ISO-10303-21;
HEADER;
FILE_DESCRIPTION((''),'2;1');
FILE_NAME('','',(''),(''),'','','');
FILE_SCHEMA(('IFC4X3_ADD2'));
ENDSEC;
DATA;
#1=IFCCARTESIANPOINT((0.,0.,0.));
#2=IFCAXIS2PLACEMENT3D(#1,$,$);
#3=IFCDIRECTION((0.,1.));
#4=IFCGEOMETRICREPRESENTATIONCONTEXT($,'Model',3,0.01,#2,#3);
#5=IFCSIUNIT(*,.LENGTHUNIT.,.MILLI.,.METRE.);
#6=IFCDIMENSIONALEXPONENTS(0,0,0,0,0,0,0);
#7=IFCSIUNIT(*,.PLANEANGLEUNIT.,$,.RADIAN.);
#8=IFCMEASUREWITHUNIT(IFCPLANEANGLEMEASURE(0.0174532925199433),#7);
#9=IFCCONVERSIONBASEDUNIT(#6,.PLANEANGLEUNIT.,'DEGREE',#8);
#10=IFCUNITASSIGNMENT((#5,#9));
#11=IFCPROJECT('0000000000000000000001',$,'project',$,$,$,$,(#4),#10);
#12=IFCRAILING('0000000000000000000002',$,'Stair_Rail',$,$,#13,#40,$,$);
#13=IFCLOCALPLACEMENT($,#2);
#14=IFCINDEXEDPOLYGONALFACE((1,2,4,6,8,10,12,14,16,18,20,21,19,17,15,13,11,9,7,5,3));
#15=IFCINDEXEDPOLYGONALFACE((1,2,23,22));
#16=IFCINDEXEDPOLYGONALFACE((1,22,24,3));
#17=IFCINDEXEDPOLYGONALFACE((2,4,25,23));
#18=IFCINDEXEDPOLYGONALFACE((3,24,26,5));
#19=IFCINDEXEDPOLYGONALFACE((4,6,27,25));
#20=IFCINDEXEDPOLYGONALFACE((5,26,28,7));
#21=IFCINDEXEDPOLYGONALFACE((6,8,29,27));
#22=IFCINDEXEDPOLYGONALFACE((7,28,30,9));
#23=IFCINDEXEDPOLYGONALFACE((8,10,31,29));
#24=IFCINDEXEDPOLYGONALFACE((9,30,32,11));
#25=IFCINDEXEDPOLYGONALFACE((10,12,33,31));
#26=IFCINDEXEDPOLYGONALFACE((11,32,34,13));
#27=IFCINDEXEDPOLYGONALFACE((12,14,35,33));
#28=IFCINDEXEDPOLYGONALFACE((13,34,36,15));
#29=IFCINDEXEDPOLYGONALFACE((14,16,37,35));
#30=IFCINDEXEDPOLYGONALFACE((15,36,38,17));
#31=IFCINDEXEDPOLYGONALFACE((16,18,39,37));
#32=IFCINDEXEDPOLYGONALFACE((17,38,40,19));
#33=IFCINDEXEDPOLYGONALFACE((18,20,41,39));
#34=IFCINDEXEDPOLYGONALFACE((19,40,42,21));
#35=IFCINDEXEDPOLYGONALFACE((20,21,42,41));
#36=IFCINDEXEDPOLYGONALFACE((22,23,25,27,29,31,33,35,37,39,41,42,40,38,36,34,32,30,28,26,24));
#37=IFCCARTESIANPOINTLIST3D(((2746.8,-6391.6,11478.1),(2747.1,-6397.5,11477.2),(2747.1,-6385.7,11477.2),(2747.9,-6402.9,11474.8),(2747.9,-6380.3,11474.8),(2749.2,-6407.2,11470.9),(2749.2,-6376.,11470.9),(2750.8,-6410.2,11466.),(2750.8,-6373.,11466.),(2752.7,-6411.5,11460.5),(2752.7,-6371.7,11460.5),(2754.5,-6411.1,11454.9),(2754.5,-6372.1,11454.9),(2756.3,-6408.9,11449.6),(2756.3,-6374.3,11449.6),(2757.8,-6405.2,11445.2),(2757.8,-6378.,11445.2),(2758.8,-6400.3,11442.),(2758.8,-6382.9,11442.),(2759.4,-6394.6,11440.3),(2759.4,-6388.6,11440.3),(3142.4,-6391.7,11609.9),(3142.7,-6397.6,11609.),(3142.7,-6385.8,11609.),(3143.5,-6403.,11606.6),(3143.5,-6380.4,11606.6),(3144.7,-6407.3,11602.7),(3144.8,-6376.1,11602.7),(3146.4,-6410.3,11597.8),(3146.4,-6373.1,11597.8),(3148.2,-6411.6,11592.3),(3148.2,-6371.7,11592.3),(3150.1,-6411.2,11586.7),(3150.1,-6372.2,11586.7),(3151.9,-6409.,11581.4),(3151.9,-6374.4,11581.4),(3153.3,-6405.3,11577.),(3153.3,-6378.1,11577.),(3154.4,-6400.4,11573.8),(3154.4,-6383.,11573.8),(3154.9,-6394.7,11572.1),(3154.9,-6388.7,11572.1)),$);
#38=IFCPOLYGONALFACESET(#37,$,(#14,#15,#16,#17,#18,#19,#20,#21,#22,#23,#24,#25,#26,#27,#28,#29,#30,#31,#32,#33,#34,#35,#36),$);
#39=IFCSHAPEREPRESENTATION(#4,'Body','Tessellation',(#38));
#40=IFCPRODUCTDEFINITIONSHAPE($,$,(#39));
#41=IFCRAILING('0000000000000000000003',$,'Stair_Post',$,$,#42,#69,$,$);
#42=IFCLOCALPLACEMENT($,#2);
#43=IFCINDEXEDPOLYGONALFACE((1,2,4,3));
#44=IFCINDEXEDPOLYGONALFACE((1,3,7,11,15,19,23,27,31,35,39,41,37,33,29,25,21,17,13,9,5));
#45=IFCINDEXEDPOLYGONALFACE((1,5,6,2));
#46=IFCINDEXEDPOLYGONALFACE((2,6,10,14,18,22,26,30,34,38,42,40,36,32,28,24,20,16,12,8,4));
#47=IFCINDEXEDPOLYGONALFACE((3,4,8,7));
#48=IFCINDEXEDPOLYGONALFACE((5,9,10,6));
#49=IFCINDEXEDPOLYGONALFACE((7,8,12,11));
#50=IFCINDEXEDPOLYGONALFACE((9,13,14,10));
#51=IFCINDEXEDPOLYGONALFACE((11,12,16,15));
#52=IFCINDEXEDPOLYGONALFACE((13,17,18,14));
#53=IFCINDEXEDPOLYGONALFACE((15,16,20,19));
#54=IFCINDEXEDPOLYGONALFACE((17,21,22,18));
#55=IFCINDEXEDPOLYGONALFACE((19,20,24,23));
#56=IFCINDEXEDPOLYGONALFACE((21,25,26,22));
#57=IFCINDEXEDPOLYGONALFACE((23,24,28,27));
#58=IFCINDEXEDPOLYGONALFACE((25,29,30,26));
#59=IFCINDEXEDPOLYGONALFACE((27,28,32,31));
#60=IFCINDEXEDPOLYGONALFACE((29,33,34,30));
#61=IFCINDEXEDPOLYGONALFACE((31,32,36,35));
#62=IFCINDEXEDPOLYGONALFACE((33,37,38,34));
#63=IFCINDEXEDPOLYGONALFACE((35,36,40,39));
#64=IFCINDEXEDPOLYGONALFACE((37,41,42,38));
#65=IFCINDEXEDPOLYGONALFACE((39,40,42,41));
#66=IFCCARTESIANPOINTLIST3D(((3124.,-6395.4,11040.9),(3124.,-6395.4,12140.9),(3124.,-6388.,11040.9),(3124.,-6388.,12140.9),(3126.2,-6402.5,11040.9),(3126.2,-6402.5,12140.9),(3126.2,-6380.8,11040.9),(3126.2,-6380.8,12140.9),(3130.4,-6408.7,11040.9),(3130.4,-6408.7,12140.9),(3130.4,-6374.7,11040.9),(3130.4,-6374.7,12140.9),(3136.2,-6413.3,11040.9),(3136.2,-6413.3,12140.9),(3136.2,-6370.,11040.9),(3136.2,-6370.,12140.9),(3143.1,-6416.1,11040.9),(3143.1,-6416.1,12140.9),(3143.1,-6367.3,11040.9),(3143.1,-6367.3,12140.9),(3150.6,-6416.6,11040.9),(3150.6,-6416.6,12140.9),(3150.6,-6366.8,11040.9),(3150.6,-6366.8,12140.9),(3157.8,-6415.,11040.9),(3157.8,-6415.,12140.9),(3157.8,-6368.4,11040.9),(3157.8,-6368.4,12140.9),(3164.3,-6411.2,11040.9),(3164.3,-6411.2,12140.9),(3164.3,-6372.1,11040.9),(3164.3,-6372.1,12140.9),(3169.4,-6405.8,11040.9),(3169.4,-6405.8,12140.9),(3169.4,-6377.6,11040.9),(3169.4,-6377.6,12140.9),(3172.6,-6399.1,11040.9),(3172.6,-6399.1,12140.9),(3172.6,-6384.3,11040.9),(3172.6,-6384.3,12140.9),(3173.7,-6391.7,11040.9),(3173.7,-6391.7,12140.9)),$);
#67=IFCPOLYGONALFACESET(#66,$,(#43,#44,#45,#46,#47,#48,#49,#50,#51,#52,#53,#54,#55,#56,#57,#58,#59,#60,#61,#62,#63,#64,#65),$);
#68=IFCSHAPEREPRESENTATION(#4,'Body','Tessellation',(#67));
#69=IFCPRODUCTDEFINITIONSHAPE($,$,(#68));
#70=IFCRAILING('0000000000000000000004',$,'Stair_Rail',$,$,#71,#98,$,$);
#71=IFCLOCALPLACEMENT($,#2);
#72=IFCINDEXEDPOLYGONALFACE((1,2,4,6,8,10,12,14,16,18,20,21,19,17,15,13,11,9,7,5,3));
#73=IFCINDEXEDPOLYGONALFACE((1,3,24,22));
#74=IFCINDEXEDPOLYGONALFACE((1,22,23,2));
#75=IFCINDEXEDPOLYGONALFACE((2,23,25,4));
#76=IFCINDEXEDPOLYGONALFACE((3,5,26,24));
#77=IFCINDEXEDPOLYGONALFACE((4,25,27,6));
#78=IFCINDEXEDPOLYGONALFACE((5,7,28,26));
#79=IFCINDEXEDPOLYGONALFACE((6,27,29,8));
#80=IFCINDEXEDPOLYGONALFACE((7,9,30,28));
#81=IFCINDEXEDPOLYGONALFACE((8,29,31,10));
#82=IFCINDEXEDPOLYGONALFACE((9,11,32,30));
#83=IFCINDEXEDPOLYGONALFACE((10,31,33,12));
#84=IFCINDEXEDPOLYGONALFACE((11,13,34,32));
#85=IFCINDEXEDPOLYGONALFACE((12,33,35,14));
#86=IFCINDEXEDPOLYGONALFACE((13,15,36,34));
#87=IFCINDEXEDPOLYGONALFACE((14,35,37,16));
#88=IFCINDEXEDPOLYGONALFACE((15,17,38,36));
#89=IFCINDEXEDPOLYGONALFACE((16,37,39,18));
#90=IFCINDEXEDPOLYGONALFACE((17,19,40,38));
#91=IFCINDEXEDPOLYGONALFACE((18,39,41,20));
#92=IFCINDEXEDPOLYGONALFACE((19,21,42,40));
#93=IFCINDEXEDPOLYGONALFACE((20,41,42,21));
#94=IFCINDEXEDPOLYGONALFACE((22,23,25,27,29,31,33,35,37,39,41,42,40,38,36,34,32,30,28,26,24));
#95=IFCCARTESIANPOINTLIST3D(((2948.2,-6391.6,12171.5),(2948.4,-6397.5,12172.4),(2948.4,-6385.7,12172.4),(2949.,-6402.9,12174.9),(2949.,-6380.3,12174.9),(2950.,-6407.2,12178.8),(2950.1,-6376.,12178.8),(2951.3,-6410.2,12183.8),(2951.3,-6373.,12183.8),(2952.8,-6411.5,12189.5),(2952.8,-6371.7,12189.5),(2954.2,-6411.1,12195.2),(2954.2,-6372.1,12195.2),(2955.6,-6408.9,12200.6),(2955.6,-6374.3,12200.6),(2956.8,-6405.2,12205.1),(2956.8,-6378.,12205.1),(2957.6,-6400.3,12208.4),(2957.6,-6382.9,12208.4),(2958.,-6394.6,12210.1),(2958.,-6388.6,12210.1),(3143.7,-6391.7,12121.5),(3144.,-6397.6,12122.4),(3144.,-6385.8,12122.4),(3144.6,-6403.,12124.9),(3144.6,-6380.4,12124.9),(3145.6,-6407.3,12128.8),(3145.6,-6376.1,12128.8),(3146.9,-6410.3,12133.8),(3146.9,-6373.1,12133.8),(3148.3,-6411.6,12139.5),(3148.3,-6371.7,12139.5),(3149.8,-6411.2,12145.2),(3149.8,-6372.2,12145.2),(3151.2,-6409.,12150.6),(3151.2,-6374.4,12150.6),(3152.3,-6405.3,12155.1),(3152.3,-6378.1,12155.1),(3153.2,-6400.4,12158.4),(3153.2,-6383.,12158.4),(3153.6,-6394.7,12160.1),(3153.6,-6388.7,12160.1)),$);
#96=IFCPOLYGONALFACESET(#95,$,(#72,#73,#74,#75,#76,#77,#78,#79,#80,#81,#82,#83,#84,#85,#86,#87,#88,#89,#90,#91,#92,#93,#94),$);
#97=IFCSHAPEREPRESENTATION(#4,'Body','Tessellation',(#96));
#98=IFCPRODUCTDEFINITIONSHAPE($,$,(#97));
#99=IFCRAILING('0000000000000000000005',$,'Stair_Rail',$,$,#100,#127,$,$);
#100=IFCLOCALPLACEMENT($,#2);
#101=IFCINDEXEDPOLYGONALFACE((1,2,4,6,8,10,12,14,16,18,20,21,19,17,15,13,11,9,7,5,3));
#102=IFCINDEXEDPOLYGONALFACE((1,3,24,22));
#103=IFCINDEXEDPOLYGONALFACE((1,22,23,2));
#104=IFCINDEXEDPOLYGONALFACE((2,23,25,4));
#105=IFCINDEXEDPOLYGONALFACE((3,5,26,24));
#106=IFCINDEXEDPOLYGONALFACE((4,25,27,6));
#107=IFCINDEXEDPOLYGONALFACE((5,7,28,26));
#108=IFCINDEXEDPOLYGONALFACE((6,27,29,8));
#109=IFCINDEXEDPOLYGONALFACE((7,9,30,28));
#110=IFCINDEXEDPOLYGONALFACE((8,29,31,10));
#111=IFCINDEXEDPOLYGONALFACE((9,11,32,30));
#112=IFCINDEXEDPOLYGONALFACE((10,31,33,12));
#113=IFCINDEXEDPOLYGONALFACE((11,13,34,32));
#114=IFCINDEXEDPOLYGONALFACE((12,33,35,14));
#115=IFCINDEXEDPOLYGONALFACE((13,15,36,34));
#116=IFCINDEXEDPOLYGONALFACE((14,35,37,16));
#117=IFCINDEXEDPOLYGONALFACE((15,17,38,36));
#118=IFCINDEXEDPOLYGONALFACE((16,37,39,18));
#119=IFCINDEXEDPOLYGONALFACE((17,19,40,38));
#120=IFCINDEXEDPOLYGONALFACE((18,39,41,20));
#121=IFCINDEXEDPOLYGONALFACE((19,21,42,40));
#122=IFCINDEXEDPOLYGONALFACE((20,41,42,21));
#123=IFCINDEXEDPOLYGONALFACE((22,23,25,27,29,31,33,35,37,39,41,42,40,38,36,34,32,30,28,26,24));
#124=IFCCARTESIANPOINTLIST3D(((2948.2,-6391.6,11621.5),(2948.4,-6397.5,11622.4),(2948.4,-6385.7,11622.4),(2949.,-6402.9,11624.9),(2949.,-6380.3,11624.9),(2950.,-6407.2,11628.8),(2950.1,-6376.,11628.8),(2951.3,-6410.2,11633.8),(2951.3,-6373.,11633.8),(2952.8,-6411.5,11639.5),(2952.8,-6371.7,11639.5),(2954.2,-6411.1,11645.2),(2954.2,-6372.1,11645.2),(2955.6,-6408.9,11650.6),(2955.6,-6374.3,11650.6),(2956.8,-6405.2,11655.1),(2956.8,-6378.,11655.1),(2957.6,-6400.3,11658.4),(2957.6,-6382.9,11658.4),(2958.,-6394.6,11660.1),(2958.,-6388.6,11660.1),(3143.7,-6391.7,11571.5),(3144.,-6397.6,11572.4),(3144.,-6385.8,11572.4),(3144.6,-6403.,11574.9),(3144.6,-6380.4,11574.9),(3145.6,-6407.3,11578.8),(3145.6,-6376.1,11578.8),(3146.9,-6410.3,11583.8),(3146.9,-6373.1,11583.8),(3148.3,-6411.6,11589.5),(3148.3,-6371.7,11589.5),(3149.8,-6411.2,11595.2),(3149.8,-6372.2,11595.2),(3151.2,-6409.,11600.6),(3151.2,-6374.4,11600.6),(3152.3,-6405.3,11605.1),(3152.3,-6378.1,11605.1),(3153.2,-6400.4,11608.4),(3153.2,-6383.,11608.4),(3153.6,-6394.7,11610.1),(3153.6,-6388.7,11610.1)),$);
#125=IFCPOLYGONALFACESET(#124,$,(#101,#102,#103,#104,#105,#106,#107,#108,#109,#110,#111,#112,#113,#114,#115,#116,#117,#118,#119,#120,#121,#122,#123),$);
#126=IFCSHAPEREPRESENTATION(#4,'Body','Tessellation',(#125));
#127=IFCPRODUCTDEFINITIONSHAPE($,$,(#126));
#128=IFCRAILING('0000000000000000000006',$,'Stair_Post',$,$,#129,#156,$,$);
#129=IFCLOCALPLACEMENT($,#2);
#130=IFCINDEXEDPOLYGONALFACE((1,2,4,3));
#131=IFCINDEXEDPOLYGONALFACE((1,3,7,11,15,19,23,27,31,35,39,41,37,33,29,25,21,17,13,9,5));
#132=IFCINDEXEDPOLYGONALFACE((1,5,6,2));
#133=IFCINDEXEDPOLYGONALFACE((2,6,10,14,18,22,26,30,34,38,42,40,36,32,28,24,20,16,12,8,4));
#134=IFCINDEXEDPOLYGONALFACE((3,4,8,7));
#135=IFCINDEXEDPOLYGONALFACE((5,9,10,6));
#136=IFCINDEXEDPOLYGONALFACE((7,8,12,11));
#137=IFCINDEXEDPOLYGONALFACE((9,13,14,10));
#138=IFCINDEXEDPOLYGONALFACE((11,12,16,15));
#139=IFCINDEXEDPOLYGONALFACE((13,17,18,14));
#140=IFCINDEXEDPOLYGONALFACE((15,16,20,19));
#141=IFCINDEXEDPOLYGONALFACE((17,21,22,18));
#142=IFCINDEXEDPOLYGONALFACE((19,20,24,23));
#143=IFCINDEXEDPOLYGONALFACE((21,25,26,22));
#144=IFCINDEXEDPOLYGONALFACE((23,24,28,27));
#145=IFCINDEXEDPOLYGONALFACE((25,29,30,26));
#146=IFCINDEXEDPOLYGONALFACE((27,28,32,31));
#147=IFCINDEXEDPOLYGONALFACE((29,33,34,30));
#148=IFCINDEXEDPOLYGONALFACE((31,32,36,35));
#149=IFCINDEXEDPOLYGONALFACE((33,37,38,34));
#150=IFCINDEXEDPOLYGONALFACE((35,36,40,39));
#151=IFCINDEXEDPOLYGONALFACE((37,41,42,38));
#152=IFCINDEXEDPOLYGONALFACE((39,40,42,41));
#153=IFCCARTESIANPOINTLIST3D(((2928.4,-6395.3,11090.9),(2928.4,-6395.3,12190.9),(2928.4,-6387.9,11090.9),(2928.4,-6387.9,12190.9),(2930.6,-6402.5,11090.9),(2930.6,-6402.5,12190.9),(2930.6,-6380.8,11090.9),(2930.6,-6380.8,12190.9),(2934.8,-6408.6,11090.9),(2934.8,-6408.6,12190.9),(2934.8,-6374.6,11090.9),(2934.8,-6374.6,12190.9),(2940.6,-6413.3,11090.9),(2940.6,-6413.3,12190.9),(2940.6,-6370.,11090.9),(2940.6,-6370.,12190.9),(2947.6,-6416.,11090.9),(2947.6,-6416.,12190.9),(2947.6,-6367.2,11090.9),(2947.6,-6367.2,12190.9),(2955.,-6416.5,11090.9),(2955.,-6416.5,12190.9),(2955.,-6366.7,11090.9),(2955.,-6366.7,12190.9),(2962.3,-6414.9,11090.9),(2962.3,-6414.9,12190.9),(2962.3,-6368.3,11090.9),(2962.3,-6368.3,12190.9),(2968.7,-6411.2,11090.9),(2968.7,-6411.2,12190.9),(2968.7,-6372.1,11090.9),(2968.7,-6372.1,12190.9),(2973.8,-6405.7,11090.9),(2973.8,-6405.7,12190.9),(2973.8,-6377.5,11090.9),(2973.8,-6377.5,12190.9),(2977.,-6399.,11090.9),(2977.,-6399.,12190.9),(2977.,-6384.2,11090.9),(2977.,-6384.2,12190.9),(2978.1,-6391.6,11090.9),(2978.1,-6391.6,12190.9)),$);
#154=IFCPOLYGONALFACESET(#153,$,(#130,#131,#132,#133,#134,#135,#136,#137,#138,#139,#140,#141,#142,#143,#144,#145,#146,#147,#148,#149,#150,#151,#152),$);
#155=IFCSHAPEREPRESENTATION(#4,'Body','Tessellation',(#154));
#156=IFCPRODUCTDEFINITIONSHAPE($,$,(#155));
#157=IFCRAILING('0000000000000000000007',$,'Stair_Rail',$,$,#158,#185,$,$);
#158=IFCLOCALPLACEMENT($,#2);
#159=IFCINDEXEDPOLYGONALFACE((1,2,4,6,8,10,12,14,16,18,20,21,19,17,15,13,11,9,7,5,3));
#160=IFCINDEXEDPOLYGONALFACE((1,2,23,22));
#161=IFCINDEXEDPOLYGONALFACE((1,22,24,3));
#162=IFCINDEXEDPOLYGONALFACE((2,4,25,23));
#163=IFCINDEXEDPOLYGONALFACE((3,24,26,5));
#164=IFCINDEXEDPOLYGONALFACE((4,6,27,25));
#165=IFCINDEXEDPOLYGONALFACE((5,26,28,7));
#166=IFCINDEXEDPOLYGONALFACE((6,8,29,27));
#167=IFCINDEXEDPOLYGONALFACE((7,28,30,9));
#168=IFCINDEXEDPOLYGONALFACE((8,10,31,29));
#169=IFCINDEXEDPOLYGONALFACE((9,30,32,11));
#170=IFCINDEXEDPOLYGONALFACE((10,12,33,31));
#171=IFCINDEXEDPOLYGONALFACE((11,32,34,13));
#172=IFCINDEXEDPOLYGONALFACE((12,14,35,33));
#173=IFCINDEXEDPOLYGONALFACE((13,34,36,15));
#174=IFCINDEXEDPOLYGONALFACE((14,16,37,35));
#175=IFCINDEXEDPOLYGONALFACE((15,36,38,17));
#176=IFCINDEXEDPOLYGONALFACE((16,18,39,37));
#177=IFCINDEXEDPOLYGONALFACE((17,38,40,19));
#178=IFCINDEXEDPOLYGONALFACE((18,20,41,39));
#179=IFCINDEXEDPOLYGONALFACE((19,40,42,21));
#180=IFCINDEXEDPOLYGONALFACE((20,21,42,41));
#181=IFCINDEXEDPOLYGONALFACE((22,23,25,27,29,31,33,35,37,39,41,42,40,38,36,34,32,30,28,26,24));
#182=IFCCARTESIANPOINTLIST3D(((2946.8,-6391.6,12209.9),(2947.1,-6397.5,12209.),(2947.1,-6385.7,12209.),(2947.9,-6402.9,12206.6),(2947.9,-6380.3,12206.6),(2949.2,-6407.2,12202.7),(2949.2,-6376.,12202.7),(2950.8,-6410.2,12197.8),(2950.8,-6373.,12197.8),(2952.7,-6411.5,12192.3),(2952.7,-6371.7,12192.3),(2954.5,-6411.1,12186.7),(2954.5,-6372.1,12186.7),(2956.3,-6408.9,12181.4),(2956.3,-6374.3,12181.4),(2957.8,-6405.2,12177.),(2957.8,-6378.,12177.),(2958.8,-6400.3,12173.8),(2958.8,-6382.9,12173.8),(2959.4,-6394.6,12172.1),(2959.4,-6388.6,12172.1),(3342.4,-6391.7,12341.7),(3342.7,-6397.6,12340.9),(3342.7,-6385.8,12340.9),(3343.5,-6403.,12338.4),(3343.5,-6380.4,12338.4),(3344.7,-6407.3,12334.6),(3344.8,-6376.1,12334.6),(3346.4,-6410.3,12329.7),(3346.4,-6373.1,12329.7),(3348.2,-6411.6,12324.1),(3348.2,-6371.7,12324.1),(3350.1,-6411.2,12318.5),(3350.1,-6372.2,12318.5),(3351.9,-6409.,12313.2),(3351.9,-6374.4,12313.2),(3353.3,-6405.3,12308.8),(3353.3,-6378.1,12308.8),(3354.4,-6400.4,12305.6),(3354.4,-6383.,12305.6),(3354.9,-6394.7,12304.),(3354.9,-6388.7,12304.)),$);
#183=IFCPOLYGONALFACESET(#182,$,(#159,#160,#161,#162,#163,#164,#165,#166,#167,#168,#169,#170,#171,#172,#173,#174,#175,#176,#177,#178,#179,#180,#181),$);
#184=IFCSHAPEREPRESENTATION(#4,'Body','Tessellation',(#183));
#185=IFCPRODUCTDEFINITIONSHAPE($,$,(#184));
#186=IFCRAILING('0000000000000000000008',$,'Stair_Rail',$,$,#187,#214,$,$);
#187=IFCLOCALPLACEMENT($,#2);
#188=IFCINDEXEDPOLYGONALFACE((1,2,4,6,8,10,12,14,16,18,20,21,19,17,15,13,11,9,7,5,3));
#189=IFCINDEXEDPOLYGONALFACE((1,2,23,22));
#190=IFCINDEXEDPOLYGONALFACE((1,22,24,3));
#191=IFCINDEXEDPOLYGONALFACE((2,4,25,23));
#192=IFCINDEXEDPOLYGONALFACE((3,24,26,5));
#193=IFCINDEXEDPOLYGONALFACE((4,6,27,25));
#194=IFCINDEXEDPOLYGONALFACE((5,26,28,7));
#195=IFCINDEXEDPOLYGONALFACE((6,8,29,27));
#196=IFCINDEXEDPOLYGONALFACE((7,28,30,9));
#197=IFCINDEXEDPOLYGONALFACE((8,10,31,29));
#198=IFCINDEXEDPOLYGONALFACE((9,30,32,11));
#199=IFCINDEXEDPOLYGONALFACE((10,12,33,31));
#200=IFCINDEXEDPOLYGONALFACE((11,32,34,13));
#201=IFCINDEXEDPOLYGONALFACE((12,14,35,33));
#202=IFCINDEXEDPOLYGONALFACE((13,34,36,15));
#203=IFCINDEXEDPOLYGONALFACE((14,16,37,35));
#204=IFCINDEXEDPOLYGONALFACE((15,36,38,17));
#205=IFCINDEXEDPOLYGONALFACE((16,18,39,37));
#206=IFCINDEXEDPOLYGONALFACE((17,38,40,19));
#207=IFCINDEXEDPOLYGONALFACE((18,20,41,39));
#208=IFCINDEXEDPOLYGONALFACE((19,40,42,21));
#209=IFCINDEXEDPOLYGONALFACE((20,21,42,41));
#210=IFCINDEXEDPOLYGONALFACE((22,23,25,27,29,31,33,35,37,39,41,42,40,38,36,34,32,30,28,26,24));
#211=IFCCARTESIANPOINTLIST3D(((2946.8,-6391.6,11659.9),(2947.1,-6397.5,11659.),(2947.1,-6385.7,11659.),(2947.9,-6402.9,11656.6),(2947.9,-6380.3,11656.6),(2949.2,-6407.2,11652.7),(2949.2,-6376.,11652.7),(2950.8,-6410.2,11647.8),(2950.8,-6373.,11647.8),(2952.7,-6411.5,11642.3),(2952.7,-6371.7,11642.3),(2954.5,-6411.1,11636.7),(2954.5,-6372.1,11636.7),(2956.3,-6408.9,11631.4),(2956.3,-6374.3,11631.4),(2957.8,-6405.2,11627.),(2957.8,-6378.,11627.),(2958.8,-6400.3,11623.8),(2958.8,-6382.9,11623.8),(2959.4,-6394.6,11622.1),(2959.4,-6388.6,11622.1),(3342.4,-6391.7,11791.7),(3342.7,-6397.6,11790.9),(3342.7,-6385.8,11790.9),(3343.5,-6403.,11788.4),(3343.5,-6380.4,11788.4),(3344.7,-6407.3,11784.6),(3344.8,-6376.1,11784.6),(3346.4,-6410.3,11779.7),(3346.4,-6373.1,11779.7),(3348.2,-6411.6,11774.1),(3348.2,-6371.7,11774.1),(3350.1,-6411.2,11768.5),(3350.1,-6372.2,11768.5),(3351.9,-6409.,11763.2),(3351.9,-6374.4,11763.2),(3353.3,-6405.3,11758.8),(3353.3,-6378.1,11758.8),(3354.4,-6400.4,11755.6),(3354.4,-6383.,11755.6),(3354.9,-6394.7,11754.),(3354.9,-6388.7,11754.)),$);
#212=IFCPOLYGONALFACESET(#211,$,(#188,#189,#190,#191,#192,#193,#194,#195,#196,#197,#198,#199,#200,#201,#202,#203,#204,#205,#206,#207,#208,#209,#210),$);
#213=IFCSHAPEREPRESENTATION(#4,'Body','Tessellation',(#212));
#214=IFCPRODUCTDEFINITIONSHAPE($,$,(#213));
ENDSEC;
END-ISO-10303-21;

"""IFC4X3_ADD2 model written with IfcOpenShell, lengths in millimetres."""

from ifc_helpers import new_model, entity, si_unit, converted_unit, direction, frame, origin, context, project, circle, extrude, element, save


model = new_model("IFC4X3_ADD2")

# Units and contexts
model_context = context("Model", 3, precision=0.01, world=origin(), true_north=direction((0.0, 1.0)))
ifc_project = project(units=[si_unit("LENGTHUNIT", "METRE", prefix="MILLI"), converted_unit("PLANEANGLEUNIT", "DEGREE", entity("IfcPlaneAngleMeasure", 0.0174532925199433), si_unit("PLANEANGLEUNIT", "RADIAN"), dimensions=[0, 0, 0, 0, 0, 0, 0])], contexts=[model_context])

# Railings
element("IfcRailing", 1, Name="Stair_Rail", context=model_context, shape_type="SweptSolid", body=[
    entity("IfcSweptDiskSolid", entity("IfcPolyline", [entity("IfcCartesianPoint", [2753.1, -6391.6, 11459.1]), entity("IfcCartesianPoint", [3148.7, -6391.7, 11590.9])]), 20.0),
])
element("IfcRailing", 2, Name="Stair_Post", context=model_context, shape_type="SweptSolid", body=[
    extrude(circle(Radius=25.0), frame((3148.7, -6391.7, 11040.9)), (0.0, 0.0, 1.0), 1100.0),
])
element("IfcRailing", 3, Name="Stair_Rail", context=model_context, shape_type="SweptSolid", body=[
    entity("IfcSweptDiskSolid", entity("IfcPolyline", [entity("IfcCartesianPoint", [3148.7, -6391.7, 12140.9]), entity("IfcCartesianPoint", [2953.1, -6391.6, 12190.9])]), 20.0),
])
element("IfcRailing", 4, Name="Stair_Rail", context=model_context, shape_type="SweptSolid", body=[
    entity("IfcSweptDiskSolid", entity("IfcPolyline", [entity("IfcCartesianPoint", [3148.7, -6391.7, 11590.9]), entity("IfcCartesianPoint", [2953.1, -6391.6, 11640.9])]), 20.0),
])
element("IfcRailing", 5, Name="Stair_Post", context=model_context, shape_type="SweptSolid", body=[
    extrude(circle(Radius=25.0), frame((2953.1, -6391.6, 11090.9)), (0.0, 0.0, 1.0), 1100.0),
])
element("IfcRailing", 6, Name="Stair_Rail", context=model_context, shape_type="SweptSolid", body=[
    entity("IfcSweptDiskSolid", entity("IfcPolyline", [entity("IfcCartesianPoint", [2953.1, -6391.6, 12190.9]), entity("IfcCartesianPoint", [3348.7, -6391.7, 12322.7])]), 20.0),
])
element("IfcRailing", 7, Name="Stair_Rail", context=model_context, shape_type="SweptSolid", body=[
    entity("IfcSweptDiskSolid", entity("IfcPolyline", [entity("IfcCartesianPoint", [2953.1, -6391.6, 11640.9]), entity("IfcCartesianPoint", [3348.7, -6391.7, 11772.7])]), 20.0),
])

save(model, "model.ifc")
